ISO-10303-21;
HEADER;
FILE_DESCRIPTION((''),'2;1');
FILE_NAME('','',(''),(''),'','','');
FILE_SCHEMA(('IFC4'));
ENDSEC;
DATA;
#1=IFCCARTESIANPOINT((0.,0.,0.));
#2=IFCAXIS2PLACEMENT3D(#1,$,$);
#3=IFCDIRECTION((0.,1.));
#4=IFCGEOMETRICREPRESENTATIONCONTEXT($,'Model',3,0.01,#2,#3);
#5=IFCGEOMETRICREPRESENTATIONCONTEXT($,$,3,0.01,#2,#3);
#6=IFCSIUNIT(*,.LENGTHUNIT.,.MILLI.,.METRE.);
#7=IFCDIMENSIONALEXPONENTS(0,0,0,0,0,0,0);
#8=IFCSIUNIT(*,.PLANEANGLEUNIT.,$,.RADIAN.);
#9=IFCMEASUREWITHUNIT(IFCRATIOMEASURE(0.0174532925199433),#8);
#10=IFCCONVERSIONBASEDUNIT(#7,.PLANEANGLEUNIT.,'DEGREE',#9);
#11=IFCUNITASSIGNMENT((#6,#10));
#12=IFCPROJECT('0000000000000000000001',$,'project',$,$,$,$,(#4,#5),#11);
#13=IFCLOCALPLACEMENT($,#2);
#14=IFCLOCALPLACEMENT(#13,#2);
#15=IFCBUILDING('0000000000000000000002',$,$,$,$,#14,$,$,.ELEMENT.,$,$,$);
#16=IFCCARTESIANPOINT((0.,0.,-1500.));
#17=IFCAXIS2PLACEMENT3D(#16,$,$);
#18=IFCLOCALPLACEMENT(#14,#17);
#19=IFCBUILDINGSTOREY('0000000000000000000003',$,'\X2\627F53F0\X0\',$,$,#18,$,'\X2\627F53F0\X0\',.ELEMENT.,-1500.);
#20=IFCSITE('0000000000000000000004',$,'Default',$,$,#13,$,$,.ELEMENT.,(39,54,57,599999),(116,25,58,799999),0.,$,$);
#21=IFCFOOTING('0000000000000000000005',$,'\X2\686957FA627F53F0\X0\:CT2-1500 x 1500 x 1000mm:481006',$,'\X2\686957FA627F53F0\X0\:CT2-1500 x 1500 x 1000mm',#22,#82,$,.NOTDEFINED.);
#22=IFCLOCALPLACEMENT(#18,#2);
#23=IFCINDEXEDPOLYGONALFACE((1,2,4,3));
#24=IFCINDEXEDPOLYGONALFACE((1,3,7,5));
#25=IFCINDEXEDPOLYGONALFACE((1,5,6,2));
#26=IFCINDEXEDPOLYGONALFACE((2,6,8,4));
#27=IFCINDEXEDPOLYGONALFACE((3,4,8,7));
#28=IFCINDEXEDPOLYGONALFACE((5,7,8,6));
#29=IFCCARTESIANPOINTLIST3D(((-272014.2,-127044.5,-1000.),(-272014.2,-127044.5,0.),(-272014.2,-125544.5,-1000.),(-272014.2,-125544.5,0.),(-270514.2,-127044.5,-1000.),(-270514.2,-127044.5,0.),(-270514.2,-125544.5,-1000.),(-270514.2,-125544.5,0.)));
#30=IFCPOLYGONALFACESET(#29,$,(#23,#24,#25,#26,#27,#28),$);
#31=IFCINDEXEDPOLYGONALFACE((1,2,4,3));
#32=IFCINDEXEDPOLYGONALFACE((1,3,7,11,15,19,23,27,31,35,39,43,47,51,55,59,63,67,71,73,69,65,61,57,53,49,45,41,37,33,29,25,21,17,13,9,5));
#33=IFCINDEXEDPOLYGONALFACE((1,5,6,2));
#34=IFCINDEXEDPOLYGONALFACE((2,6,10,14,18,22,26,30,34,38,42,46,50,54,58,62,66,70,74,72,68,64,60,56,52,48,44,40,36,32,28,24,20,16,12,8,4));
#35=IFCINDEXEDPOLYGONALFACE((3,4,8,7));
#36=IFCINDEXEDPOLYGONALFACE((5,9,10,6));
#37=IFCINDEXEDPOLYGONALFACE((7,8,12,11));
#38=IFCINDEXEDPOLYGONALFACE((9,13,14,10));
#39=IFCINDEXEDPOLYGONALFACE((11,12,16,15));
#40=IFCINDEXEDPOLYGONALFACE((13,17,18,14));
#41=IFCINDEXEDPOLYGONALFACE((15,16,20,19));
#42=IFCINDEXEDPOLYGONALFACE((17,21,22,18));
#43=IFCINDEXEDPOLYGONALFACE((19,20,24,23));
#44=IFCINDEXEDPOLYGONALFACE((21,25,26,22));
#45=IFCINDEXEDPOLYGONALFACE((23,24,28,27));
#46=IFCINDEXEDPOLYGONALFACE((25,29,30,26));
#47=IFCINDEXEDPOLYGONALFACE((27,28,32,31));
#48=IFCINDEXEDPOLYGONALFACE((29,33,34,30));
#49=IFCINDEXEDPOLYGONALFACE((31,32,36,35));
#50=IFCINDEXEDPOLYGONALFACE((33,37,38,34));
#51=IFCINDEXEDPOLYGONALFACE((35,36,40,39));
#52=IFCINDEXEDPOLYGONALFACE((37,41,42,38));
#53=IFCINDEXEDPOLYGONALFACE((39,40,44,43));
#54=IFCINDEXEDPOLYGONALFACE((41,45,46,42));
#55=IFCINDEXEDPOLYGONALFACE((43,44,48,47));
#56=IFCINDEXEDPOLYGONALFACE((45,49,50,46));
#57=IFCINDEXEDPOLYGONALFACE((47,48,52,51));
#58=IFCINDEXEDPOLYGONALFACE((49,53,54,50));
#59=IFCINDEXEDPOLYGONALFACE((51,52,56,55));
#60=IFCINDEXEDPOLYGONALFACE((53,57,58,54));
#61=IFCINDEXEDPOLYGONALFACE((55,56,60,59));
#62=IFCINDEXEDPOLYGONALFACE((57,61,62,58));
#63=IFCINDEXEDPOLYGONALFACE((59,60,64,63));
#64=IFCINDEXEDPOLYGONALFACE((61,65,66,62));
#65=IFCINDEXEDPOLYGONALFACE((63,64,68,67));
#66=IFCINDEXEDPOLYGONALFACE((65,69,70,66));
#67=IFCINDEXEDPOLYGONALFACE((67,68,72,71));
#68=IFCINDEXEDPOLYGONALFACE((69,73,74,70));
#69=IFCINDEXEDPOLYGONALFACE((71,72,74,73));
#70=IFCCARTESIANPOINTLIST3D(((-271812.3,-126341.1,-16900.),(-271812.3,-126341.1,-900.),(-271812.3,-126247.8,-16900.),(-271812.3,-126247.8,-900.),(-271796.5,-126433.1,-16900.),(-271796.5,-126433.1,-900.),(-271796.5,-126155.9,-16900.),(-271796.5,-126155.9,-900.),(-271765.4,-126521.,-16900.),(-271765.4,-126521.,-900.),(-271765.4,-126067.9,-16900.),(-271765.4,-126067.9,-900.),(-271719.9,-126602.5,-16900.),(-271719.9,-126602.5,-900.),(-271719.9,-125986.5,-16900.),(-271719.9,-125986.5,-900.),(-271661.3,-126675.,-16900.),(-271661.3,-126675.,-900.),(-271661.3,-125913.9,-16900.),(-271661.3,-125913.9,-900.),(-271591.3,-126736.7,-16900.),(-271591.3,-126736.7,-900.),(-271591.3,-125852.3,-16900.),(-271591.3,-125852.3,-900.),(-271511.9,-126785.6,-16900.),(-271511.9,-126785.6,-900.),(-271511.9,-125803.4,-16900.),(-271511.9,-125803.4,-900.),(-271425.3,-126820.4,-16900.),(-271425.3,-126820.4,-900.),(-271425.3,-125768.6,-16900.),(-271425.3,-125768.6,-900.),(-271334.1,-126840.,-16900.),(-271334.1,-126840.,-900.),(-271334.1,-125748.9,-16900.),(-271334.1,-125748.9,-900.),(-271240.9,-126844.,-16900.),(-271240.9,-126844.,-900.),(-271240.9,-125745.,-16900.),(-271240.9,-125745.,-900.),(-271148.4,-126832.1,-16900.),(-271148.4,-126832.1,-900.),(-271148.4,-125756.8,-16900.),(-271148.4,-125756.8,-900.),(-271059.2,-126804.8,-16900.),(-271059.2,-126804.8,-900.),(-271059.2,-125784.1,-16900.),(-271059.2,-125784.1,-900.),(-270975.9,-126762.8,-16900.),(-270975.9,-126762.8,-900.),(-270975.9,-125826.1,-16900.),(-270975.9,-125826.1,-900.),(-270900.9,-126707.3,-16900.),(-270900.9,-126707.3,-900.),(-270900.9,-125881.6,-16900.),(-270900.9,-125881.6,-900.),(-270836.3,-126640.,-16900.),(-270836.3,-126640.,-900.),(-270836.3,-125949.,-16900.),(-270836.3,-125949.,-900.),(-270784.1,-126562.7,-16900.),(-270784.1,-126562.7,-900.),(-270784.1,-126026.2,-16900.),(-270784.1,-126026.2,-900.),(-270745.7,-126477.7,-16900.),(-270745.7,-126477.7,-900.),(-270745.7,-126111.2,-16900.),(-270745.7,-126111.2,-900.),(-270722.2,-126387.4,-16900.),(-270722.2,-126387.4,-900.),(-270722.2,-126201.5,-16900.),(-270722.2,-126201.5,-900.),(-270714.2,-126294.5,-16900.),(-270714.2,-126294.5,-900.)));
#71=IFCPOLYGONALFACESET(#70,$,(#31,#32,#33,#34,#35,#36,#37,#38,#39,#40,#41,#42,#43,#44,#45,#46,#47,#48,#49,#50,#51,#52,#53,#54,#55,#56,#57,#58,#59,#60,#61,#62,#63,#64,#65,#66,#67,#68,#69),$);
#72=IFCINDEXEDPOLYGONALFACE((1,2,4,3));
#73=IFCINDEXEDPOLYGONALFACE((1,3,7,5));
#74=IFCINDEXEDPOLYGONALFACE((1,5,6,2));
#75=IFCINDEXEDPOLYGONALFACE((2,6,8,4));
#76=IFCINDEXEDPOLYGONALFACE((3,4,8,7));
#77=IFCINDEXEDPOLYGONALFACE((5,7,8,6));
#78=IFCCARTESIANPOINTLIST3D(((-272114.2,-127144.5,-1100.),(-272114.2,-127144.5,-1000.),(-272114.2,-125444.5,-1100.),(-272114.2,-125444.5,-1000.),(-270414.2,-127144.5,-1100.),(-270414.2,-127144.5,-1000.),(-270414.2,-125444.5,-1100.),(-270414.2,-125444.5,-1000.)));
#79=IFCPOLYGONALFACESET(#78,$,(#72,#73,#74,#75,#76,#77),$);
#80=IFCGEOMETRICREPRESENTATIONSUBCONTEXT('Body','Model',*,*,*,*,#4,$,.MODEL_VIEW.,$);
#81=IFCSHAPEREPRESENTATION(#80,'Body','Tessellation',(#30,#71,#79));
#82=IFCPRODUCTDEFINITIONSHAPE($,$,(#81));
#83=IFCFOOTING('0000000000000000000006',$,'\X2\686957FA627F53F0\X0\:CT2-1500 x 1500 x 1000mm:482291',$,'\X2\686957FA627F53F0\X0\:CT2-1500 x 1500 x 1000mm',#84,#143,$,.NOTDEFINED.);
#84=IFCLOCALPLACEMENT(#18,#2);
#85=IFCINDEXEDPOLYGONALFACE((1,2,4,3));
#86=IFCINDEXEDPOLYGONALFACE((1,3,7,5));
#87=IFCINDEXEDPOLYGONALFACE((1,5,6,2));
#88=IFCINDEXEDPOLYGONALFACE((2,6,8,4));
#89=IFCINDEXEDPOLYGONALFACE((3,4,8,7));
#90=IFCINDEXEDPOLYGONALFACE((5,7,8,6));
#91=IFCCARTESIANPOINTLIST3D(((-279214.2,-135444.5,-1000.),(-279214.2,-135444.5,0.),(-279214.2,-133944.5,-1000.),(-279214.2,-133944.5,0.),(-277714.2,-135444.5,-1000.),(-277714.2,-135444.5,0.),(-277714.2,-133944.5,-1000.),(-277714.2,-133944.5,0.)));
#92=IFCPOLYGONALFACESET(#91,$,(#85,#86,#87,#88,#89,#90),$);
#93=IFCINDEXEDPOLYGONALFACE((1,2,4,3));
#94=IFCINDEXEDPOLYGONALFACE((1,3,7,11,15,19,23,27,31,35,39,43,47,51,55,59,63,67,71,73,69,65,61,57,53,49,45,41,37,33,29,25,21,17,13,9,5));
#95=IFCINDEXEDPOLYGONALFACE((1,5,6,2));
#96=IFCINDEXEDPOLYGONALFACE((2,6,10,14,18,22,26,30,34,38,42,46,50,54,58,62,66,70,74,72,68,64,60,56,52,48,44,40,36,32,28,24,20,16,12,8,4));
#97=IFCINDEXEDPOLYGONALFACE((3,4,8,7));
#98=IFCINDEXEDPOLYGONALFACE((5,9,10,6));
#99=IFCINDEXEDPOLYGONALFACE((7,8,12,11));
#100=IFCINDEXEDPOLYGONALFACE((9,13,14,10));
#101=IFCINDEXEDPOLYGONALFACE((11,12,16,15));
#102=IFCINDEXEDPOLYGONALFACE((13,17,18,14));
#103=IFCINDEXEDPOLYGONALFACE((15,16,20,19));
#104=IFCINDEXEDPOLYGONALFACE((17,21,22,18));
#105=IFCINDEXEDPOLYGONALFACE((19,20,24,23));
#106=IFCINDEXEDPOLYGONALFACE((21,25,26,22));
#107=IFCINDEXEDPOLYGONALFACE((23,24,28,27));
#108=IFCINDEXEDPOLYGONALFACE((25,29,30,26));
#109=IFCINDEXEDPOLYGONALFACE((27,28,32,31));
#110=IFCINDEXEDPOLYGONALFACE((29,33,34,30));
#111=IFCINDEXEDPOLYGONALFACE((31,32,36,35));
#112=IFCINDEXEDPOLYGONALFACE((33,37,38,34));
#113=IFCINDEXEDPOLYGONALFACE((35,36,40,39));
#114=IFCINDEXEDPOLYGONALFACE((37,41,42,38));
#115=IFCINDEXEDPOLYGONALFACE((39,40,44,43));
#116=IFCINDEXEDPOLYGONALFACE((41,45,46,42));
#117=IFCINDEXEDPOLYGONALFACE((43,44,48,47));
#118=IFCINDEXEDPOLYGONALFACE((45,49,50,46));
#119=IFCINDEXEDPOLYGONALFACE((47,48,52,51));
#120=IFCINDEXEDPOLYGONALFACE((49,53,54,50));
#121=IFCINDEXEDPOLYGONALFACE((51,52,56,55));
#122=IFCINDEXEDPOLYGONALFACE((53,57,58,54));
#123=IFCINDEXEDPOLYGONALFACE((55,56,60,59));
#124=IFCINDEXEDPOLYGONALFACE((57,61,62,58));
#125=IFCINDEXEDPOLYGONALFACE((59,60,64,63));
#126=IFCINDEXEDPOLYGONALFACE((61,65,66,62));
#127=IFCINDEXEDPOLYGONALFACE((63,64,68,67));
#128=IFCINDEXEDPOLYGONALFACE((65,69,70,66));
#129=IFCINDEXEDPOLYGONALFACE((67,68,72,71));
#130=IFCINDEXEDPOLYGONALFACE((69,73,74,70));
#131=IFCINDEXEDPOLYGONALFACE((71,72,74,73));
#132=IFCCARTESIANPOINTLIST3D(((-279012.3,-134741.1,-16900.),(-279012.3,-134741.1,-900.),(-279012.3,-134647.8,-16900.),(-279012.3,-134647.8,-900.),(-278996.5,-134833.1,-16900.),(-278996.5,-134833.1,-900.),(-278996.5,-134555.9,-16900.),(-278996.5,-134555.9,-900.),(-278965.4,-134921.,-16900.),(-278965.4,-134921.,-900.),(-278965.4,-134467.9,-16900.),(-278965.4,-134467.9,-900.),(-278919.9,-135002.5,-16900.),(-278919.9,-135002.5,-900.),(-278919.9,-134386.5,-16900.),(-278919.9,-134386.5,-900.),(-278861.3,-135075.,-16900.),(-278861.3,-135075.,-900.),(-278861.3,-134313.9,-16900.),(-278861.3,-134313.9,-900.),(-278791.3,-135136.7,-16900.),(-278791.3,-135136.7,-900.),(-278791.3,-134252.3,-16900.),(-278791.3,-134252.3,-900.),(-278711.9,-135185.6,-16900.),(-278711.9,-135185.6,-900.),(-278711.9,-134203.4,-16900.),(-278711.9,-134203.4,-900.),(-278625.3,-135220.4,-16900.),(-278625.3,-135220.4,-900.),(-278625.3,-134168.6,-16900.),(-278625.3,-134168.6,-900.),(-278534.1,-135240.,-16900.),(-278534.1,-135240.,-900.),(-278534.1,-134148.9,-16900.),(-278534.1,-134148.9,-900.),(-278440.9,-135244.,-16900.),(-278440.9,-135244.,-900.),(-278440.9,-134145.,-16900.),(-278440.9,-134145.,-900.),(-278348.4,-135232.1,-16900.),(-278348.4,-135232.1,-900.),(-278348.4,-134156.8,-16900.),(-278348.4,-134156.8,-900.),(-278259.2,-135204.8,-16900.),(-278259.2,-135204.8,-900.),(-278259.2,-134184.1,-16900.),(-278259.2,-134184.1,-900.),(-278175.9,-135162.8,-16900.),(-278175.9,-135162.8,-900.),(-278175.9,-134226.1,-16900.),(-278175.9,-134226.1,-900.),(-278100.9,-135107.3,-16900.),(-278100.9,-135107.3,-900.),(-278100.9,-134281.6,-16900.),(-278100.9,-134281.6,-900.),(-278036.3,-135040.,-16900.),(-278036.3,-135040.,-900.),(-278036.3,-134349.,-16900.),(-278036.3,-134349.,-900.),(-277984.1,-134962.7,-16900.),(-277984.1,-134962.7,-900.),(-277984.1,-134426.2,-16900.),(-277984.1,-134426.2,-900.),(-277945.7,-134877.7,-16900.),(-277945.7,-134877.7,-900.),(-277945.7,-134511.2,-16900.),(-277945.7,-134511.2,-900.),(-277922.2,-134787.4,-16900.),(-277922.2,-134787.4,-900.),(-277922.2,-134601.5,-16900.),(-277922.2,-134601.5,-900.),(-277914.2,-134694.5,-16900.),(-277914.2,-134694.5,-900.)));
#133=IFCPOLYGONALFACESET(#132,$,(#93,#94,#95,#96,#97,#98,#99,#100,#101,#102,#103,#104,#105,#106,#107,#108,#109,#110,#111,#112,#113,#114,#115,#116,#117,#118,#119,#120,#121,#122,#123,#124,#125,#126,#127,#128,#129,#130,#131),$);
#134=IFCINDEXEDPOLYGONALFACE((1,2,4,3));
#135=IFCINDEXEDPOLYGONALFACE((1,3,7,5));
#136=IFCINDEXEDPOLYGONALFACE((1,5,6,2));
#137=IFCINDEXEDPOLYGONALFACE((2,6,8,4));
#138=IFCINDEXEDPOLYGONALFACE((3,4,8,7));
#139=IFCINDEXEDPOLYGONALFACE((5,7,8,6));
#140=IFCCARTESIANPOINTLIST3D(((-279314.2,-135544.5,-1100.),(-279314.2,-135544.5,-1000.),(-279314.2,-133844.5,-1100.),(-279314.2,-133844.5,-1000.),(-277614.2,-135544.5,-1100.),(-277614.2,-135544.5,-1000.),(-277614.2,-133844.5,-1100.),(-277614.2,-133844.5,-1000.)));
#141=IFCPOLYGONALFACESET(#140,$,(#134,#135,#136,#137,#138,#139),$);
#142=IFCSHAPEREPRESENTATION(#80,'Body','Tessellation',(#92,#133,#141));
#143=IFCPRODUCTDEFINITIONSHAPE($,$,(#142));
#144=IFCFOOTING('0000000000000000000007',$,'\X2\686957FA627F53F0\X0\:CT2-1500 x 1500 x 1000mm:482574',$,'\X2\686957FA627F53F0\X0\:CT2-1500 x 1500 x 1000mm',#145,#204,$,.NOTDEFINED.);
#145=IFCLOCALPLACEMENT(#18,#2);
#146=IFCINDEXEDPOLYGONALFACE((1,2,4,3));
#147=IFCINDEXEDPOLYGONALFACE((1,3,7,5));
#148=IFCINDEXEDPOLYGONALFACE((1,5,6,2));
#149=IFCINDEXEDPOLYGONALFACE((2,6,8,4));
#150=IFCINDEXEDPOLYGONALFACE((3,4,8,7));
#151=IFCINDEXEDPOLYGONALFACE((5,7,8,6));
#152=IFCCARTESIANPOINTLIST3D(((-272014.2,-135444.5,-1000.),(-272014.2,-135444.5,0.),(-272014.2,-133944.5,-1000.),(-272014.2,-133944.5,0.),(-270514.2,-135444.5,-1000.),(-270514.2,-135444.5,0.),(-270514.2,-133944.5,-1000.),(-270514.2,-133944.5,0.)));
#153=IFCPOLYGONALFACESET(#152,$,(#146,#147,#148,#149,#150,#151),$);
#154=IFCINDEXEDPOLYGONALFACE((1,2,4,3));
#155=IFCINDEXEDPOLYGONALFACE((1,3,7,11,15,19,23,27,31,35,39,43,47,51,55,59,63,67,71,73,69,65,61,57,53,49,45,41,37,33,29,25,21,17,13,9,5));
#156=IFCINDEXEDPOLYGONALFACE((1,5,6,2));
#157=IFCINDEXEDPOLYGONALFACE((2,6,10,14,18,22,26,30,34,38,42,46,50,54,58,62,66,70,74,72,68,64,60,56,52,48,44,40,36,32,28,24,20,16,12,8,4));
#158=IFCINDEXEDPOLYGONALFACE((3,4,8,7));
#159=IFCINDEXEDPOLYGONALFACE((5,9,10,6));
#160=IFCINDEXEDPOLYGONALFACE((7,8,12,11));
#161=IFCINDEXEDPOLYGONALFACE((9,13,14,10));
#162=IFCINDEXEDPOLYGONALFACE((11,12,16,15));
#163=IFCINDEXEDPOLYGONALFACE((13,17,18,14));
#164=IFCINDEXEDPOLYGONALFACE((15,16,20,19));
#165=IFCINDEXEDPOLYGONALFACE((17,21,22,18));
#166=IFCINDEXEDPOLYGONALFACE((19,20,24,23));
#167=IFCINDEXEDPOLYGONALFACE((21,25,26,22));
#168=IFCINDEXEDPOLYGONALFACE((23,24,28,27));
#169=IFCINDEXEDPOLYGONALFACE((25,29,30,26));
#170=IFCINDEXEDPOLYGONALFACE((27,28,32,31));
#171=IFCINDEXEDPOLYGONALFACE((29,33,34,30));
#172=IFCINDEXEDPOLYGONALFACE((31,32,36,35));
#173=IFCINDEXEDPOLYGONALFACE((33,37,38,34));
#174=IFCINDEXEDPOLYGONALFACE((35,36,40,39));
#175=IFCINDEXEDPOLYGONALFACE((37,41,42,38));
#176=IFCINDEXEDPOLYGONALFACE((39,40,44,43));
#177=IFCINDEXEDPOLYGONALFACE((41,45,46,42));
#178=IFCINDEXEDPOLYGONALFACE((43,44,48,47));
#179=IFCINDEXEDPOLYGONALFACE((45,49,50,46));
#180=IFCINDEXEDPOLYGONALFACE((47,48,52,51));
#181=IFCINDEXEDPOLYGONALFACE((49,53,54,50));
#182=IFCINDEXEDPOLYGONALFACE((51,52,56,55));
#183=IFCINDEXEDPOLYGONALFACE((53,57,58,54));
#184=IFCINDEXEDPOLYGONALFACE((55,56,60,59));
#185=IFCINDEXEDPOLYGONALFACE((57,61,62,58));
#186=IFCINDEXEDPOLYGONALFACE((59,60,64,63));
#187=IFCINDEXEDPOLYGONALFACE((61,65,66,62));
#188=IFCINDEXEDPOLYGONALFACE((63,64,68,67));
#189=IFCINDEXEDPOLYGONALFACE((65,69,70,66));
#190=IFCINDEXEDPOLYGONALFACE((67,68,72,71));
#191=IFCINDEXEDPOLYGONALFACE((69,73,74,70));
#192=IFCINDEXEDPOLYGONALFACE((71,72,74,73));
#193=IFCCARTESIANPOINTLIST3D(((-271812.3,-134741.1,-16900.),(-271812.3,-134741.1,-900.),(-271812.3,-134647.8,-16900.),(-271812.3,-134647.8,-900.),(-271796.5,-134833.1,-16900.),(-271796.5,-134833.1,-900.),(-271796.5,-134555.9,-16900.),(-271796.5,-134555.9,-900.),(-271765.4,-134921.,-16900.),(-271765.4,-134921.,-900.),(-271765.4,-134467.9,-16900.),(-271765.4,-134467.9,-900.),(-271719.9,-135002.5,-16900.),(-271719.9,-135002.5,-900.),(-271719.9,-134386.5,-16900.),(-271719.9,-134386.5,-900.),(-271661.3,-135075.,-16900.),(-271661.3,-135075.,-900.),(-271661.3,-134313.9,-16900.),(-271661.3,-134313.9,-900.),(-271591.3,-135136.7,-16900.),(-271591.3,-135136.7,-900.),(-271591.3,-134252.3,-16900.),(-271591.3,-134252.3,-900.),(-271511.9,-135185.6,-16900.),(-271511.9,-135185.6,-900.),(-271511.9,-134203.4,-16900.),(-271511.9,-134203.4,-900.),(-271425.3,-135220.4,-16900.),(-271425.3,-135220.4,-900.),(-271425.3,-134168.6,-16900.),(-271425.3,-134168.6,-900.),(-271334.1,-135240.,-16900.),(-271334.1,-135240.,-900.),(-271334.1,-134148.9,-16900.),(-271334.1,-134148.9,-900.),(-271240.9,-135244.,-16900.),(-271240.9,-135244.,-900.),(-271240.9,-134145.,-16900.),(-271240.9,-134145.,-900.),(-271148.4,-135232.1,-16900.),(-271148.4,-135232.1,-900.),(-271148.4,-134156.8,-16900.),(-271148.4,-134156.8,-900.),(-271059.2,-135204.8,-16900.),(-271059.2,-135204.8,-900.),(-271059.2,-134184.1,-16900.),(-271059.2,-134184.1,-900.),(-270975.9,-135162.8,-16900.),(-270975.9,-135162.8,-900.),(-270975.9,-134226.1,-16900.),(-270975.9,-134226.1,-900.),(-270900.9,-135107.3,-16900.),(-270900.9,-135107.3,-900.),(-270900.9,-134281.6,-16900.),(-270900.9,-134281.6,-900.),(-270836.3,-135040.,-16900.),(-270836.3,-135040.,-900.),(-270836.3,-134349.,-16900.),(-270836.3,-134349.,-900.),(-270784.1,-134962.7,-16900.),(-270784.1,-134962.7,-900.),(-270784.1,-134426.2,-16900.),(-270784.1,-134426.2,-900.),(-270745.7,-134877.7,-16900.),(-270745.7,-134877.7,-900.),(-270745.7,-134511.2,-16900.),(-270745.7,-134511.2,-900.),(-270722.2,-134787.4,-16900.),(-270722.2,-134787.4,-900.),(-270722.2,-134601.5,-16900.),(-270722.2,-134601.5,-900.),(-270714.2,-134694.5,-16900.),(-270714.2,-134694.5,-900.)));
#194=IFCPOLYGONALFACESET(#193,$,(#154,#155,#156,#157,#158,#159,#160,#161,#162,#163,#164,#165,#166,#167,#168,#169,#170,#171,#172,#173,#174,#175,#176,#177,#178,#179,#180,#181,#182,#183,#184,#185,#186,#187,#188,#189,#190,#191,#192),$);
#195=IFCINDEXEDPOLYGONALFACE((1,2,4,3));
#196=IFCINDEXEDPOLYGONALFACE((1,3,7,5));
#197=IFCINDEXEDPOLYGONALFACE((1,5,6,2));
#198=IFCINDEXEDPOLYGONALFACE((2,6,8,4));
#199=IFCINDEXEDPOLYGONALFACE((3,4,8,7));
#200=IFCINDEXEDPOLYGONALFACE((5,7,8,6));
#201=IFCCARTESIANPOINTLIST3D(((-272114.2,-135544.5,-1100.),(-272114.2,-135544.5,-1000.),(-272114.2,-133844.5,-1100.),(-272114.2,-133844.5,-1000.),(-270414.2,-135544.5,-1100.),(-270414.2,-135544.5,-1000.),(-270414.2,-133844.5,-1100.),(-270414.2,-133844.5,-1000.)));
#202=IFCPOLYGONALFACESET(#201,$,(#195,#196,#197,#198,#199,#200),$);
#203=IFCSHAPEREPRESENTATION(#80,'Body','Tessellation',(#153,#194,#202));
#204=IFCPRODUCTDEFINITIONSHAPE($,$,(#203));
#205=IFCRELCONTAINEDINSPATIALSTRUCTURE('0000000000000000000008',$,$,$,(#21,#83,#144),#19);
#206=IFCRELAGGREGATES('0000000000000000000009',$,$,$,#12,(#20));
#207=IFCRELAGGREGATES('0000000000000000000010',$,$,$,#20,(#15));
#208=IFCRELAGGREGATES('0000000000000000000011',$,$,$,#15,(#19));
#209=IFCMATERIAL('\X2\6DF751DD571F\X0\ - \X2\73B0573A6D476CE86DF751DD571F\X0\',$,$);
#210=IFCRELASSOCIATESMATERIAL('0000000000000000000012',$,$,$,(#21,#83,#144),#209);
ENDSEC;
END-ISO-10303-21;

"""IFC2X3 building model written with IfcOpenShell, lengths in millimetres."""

from ifc_helpers import new_model, entity, si_unit, converted_unit, direction, frame, frame_2d, origin, origin_2d_with_axis, place, context, subcontext, project, spatial, rectangle, circle, extrude, material, element, save


model = new_model("IFC2X3")

# Units and contexts
model_context = context("Model", 3, precision=0.01, world=origin(), true_north=direction((0.0, 1.0)))
context_of_model = context(None, 3, precision=0.01, world=origin(), true_north=direction((0.0, 1.0)))
body_context = subcontext(model_context, "Body", "Model", "MODEL_VIEW")
ifc_project = project(units=[si_unit("LENGTHUNIT", "METRE", prefix="MILLI"), converted_unit("PLANEANGLEUNIT", "DEGREE", entity("IfcRatioMeasure", 0.0174532925199433), si_unit("PLANEANGLEUNIT", "RADIAN"), dimensions=[0, 0, 0, 0, 0, 0, 0])], contexts=[model_context, context_of_model])

# Site, building, storey
site_placement = place(None, origin())
site = spatial("IfcSite", under=ifc_project, at=site_placement, Name="Default", CompositionType="ELEMENT", RefLatitude=(39, 54, 57, 599999), RefLongitude=(116, 25, 58, 799999), RefElevation=0.0)
building_placement = place(site_placement, origin())
building = spatial("IfcBuilding", under=site, at=building_placement, CompositionType="ELEMENT")
storey_placement = place(building_placement, frame((0.0, 0.0, -1500.0)))
storey = spatial("IfcBuildingStorey", under=building, at=storey_placement, Name="承台", LongName="承台", CompositionType="ELEMENT", Elevation=-1500.0)

# Footings
ifc_material_1 = material(Name="混凝土 - 现场浇注混凝土")
for number, where, name in (
    (1, (-272114.2, -127144.5, -16900.0), "桩基承台:CT2-1500 x 1500 x 1000mm:481006"),
):
    element("IfcFooting", number, at=place(storey_placement, frame(where)), inside=storey, material=ifc_material_1, Name=name, ObjectType="桩基承台:CT2-1500 x 1500 x 1000mm", PredefinedType="NOTDEFINED", context=body_context, shape_type="SweptSolid", body=[
        extrude(rectangle(XDim=1500.0, YDim=1500.0, at=origin_2d_with_axis()), frame((850.0, 850.0, 15900.0), z_axis=(0.0, 0.0, 1.0), x_axis=(-1.0, 0.0, 0.0)), (0.0, 0.0, 1.0), 1000.0),
        extrude(circle(Radius=550.0, at=origin_2d_with_axis()), frame((850.0, 850.0, 0.0)), (0.0, 0.0, 1.0), 16000.0),
        extrude(rectangle(XDim=1700.0, YDim=1700.0, at=frame_2d((0.0, 0.0), x_axis=(1.0, 0.0))), frame((850.0, 850.0, 15800.0), z_axis=(0.0, 0.0, 1.0), x_axis=(0.0, 1.0, 0.0)), (0.0, 0.0, 1.0), 100.0),
    ])
for number, where, name in (
    (2, (-279314.2, -135544.5, -16900.0), "桩基承台:CT2-1500 x 1500 x 1000mm:482291"),
    (3, (-272114.2, -135544.5, -16900.0), "桩基承台:CT2-1500 x 1500 x 1000mm:482574"),
):
    element("IfcFooting", number, at=place(storey_placement, frame(where)), inside=storey, material=ifc_material_1, Name=name, ObjectType="桩基承台:CT2-1500 x 1500 x 1000mm", PredefinedType="NOTDEFINED", context=body_context, shape_type="SweptSolid", body=[
        extrude(rectangle(XDim=1500.0, YDim=1500.0, at=origin_2d_with_axis()), frame((850.0, 850.0, 15900.0), z_axis=(0.0, 0.0, 1.0), x_axis=(-1.0, 0.0, 0.0)), (0.0, 0.0, 1.0), 1000.0),
        extrude(circle(Radius=550.0, at=origin_2d_with_axis()), frame((850.0, 850.0, 0.0)), (0.0, 0.0, 1.0), 16000.0),
        extrude(rectangle(XDim=1700.0, YDim=1700.0, at=frame_2d((0.0, 0.0), x_axis=(1.0, 0.0))), frame((850.0, 850.0, 15800.0), z_axis=(0.0, 0.0, 1.0), x_axis=(0.0, 1.0, 0.0)), (0.0, 0.0, 1.0), 100.0),
    ])

save(model, "model.ifc")
